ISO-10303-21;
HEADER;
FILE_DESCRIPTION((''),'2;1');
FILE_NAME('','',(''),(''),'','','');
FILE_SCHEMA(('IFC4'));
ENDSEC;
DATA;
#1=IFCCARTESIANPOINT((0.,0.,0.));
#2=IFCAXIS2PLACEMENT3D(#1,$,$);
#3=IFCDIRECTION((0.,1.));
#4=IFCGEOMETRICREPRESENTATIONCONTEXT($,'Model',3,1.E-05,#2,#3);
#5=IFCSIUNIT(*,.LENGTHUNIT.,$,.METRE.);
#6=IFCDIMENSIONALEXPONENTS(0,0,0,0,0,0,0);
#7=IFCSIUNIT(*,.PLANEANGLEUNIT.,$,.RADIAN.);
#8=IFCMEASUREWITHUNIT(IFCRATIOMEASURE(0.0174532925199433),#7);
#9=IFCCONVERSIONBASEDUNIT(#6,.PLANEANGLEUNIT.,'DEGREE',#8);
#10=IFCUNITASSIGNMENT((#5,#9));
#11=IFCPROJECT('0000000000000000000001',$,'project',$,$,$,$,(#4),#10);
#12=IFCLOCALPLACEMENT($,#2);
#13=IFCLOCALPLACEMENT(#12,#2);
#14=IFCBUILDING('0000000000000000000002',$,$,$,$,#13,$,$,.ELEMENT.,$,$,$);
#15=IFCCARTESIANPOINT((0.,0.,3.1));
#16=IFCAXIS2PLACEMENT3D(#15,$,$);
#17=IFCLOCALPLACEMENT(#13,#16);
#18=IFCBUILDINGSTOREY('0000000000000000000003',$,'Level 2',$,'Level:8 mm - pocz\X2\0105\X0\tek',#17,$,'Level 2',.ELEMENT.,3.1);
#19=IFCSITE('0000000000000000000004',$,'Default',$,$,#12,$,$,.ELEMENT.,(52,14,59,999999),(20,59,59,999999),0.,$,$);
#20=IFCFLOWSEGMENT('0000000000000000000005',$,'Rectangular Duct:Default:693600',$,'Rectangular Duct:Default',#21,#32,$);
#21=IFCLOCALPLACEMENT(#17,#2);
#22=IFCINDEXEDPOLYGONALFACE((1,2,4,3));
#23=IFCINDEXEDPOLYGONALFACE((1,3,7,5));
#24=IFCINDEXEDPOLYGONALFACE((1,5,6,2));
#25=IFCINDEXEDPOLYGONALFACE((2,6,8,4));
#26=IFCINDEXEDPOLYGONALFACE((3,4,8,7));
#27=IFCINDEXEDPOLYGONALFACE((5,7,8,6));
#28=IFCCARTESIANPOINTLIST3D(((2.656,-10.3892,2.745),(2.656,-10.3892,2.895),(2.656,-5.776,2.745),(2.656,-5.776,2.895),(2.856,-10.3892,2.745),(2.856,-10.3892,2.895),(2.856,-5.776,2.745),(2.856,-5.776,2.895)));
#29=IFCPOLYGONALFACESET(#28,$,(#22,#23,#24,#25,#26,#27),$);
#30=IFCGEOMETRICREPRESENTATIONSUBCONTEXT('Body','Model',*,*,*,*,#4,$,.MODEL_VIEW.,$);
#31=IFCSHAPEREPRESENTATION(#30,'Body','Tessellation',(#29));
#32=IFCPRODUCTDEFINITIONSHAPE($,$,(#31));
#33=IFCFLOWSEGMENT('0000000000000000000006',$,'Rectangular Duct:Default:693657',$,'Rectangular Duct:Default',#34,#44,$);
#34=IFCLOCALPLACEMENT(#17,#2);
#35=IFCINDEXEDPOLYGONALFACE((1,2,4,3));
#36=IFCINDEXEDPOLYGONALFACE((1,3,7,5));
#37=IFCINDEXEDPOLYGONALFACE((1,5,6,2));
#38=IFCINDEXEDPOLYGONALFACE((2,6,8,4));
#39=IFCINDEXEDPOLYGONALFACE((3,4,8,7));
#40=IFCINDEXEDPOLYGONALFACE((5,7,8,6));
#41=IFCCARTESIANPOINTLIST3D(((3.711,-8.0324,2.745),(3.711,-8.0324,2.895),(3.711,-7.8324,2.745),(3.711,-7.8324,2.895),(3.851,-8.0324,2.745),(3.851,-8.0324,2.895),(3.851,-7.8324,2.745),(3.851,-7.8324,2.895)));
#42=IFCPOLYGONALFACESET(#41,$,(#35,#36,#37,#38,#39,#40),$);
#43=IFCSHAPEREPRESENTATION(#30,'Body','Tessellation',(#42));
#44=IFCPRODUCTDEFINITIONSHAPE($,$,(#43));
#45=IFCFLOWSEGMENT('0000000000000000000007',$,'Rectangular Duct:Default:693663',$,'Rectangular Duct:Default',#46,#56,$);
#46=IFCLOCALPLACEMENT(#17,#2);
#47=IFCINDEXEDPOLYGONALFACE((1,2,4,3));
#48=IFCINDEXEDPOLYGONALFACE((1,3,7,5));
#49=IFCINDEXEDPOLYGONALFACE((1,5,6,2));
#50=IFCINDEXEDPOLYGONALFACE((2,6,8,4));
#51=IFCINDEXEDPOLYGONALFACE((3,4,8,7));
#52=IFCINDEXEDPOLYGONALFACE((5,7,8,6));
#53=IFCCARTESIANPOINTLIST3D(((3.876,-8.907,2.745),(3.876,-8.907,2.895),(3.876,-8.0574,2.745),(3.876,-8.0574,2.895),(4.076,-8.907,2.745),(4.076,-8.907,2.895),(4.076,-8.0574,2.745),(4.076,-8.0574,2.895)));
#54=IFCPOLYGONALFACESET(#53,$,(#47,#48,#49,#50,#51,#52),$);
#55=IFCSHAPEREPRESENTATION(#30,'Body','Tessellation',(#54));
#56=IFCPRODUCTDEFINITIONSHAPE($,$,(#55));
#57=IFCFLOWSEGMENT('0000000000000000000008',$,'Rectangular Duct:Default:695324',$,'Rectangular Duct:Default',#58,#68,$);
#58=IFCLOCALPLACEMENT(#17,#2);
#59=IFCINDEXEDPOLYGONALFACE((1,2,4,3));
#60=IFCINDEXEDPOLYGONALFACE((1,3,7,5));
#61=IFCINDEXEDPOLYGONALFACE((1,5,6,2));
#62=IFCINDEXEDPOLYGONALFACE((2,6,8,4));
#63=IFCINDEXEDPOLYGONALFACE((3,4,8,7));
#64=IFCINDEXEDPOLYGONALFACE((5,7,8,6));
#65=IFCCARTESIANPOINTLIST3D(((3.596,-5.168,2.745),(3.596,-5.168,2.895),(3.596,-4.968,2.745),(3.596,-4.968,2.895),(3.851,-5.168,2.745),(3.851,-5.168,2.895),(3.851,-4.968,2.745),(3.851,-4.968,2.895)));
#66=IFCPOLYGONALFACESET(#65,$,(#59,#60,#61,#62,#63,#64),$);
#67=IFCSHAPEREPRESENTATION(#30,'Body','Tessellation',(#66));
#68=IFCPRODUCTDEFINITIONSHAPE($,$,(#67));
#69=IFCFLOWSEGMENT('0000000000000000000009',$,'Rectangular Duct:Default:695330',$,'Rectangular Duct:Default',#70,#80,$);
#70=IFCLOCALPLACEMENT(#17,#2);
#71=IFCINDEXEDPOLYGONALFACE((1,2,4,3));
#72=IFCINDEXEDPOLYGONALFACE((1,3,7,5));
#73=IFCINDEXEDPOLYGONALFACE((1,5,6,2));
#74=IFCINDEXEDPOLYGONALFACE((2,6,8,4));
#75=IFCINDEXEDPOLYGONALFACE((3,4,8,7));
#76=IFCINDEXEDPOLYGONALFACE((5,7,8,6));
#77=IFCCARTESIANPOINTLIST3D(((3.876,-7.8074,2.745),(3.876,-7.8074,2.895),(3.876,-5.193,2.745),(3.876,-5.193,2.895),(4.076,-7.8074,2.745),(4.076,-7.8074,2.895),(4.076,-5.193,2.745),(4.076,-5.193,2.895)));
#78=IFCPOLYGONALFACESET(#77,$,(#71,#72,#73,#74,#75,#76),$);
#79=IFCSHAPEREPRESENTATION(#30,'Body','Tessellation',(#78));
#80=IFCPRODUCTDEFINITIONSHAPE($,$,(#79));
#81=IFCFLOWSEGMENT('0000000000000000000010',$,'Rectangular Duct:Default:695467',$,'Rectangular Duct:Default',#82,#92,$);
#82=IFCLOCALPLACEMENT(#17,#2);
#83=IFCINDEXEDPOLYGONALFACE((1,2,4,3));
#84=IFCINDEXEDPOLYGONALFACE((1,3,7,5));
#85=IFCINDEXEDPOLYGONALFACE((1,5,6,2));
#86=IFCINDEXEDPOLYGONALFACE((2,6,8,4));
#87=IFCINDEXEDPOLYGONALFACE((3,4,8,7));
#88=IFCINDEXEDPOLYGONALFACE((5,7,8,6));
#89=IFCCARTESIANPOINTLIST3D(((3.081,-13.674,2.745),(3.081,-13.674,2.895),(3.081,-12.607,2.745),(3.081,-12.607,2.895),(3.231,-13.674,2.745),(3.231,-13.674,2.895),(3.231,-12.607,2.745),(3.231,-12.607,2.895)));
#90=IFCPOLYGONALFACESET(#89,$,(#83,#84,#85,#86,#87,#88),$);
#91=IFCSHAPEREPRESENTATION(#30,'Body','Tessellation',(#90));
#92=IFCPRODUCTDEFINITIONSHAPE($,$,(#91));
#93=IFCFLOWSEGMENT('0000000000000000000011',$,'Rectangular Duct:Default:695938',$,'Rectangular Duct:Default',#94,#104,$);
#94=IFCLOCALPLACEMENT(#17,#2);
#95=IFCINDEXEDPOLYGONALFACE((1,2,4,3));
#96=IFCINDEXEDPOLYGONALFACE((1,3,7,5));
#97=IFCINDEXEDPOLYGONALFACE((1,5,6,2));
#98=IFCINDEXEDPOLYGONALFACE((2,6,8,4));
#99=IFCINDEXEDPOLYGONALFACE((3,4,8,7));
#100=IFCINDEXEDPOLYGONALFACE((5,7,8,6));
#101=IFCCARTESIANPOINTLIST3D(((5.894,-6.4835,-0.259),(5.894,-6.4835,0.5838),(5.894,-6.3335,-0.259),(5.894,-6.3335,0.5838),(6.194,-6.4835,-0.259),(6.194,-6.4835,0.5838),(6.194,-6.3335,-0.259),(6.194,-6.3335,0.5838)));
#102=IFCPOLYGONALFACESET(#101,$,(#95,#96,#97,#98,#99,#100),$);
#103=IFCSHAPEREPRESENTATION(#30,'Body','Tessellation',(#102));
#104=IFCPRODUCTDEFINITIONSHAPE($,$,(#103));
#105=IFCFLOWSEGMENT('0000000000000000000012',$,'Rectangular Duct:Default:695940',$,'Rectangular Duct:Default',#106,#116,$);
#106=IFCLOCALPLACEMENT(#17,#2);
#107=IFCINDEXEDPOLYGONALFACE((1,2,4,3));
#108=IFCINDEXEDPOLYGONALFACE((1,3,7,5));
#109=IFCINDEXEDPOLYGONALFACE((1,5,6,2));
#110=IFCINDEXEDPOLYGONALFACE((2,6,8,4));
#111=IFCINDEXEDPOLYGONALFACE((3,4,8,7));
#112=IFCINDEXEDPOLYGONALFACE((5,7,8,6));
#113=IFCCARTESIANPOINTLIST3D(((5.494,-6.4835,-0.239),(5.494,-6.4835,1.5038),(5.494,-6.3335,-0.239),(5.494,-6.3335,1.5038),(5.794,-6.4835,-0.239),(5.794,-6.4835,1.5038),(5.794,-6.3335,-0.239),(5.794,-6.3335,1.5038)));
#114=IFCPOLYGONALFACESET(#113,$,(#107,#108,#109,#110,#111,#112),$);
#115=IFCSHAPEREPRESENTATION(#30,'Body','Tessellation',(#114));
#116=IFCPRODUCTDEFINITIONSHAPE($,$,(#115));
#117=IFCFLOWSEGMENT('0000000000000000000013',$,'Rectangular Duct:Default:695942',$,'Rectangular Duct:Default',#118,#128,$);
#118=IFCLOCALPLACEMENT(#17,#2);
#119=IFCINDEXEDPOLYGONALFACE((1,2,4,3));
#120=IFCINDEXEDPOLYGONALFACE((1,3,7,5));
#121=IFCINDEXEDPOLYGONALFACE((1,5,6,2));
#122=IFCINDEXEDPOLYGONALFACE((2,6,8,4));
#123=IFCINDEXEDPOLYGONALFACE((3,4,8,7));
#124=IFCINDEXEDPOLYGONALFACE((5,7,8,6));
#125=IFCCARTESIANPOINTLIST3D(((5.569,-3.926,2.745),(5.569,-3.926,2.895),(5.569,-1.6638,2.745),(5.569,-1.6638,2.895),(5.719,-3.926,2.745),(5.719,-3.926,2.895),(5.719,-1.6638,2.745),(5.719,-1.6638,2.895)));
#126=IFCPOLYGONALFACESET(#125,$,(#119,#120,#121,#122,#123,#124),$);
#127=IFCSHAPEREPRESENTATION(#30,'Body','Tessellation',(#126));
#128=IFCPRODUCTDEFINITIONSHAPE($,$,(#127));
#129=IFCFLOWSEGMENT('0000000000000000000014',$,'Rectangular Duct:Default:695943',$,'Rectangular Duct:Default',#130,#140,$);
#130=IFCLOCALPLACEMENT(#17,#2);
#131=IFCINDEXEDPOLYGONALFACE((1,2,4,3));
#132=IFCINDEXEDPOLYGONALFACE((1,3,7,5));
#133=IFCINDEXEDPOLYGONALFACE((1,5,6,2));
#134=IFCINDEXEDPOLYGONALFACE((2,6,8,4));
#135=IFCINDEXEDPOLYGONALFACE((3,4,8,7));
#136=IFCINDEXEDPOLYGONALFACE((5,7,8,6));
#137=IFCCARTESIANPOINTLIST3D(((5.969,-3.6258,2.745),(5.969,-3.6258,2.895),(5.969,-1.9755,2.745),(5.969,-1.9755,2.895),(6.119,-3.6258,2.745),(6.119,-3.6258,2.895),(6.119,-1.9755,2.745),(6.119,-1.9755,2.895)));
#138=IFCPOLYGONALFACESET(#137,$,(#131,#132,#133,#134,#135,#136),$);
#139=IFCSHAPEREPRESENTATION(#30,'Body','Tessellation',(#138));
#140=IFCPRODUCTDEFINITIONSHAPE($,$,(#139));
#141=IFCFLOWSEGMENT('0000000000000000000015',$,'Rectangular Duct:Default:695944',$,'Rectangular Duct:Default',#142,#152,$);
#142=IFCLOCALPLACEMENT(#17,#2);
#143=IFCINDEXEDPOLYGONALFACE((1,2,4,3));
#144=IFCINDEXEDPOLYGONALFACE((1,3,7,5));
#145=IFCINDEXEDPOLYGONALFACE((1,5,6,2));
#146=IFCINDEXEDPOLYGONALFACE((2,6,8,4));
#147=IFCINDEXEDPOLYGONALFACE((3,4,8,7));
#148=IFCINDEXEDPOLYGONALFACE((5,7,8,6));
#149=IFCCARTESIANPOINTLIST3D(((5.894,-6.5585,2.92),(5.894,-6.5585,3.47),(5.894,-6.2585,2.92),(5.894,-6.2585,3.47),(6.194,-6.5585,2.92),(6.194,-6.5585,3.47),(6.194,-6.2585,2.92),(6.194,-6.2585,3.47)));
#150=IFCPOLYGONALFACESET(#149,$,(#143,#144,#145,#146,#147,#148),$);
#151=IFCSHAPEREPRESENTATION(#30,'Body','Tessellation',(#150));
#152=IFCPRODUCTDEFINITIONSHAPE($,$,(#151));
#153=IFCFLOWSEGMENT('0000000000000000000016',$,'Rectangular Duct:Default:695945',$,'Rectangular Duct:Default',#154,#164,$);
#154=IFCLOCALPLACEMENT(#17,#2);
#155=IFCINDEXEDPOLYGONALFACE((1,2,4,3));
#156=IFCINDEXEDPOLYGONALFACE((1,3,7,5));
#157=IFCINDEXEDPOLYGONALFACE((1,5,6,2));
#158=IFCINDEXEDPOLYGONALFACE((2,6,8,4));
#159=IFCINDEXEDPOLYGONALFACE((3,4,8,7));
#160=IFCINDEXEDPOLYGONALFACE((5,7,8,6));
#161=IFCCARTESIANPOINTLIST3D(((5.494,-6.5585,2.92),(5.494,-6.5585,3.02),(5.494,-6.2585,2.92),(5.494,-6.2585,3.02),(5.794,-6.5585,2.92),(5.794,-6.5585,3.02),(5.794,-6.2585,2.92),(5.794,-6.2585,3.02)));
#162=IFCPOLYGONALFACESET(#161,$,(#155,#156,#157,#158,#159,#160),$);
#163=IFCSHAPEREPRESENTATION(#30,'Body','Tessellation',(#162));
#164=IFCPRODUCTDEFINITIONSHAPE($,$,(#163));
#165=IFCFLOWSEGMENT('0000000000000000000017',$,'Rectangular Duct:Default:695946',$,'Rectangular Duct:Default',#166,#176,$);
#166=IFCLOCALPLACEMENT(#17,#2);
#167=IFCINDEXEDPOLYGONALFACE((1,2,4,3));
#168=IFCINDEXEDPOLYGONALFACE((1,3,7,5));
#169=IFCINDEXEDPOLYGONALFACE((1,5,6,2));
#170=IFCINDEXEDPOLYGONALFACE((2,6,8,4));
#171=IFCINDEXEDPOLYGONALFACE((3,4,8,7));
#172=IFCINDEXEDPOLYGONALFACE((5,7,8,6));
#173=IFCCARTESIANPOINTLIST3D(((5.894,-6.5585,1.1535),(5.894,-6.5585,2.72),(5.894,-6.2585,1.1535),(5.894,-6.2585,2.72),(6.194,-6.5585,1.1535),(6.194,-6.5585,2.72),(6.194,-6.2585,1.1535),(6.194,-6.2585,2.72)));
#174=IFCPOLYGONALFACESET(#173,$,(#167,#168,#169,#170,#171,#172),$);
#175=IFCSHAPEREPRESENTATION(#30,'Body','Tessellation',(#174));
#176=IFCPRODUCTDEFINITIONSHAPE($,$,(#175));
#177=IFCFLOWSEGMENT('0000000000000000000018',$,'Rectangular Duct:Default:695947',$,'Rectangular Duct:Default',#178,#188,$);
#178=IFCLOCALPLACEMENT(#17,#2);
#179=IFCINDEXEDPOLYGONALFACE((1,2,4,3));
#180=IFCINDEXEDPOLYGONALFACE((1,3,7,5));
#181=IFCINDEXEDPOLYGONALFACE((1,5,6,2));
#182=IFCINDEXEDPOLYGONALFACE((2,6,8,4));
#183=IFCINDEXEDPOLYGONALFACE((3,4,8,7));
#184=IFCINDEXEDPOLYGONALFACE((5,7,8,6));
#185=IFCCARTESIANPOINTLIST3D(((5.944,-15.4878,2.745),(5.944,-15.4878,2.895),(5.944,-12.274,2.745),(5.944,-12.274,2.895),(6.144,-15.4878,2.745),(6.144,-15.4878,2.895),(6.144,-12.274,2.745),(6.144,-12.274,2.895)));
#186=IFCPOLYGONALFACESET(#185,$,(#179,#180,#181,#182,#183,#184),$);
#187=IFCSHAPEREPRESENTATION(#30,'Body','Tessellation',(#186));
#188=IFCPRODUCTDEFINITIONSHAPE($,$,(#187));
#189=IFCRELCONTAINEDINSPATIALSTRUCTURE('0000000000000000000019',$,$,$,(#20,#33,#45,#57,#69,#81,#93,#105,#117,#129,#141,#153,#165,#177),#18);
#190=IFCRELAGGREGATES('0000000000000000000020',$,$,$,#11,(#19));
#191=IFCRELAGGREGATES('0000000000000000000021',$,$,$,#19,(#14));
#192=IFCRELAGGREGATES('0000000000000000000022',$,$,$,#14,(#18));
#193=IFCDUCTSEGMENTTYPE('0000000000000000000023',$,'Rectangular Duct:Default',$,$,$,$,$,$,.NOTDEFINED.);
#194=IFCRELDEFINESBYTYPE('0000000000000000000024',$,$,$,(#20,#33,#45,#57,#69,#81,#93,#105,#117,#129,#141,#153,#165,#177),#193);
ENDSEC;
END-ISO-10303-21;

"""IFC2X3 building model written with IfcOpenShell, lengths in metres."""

from ifc_helpers import new_model, entity, si_unit, converted_unit, direction, frame, frame_2d, origin, origin_2d_with_axis, place, context, subcontext, project, spatial, rectangle, extrude, type_object, element, save


model = new_model("IFC2X3")

# Units and contexts
model_context = context("Model", 3, precision=1e-05, world=origin(), true_north=direction((0.0, 1.0)))
body_context = subcontext(model_context, "Body", "Model", "MODEL_VIEW")
ifc_project = project(units=[si_unit("LENGTHUNIT", "METRE"), converted_unit("PLANEANGLEUNIT", "DEGREE", entity("IfcRatioMeasure", 0.0174532925199433), si_unit("PLANEANGLEUNIT", "RADIAN"), dimensions=[0, 0, 0, 0, 0, 0, 0])], contexts=[model_context])

# Site, building, storey
site_placement = place(None, origin())
site = spatial("IfcSite", under=ifc_project, at=site_placement, Name="Default", CompositionType="ELEMENT", RefLatitude=(52, 14, 59, 999999), RefLongitude=(20, 59, 59, 999999), RefElevation=0.0)
building_placement = place(site_placement, origin())
building = spatial("IfcBuilding", under=site, at=building_placement, CompositionType="ELEMENT")
storey_placement = place(building_placement, frame((0.0, 0.0, 3.1)))
storey = spatial("IfcBuildingStorey", under=building, at=storey_placement, Name="Level 2", ObjectType="Level:8 mm - początek", LongName="Level 2", CompositionType="ELEMENT", Elevation=3.1)

# Flow segments
duct_segment_type = type_object("IfcDuctSegmentType", Name="Rectangular Duct:Default", PredefinedType="NOTDEFINED")
flow_segment_1_placement = place(storey_placement, origin())
element("IfcFlowSegment", 1, at=flow_segment_1_placement, inside=storey, type_object=duct_segment_type, Name="Rectangular Duct:Default:693600", ObjectType="Rectangular Duct:Default", context=body_context, shape_type="SweptSolid", body=[
    extrude(rectangle(XDim=4.6132, YDim=0.2, at=frame_2d((0.0, 0.0), x_axis=(1.0, 0.0))), frame((2.756, -8.0826, 2.745), z_axis=(0.0, 0.0, 1.0), x_axis=(0.0, 1.0, 0.0)), (0.0, 0.0, 1.0), 0.15),
])
flow_segment_2_placement = place(storey_placement, origin())
element("IfcFlowSegment", 2, at=flow_segment_2_placement, inside=storey, type_object=duct_segment_type, Name="Rectangular Duct:Default:693657", ObjectType="Rectangular Duct:Default", context=body_context, shape_type="SweptSolid", body=[
    extrude(rectangle(XDim=0.14, YDim=0.2, at=frame_2d((0.0, 0.0), x_axis=(1.0, 0.0))), frame((3.781, -7.9324, 2.745), z_axis=(0.0, 0.0, 1.0), x_axis=(-1.0, 0.0, 0.0)), (0.0, 0.0, 1.0), 0.15),
])
flow_segment_3_placement = place(storey_placement, origin())
element("IfcFlowSegment", 3, at=flow_segment_3_placement, inside=storey, type_object=duct_segment_type, Name="Rectangular Duct:Default:693663", ObjectType="Rectangular Duct:Default", context=body_context, shape_type="SweptSolid", body=[
    extrude(rectangle(XDim=0.8496, YDim=0.2, at=frame_2d((0.0, 0.0), x_axis=(1.0, 0.0))), frame((3.976, -8.4822, 2.745), z_axis=(0.0, 0.0, 1.0), x_axis=(0.0, 1.0, 0.0)), (0.0, 0.0, 1.0), 0.15),
])
flow_segment_4_placement = place(storey_placement, origin())
element("IfcFlowSegment", 4, at=flow_segment_4_placement, inside=storey, type_object=duct_segment_type, Name="Rectangular Duct:Default:695324", ObjectType="Rectangular Duct:Default", context=body_context, shape_type="SweptSolid", body=[
    extrude(rectangle(XDim=0.255, YDim=0.2, at=origin_2d_with_axis()), frame((3.7235, -5.068, 2.745), z_axis=(0.0, 0.0, 1.0), x_axis=(-1.0, 0.0, 0.0)), (0.0, 0.0, 1.0), 0.15),
])
flow_segment_5_placement = place(storey_placement, origin())
element("IfcFlowSegment", 5, at=flow_segment_5_placement, inside=storey, type_object=duct_segment_type, Name="Rectangular Duct:Default:695330", ObjectType="Rectangular Duct:Default", context=body_context, shape_type="SweptSolid", body=[
    extrude(rectangle(XDim=2.6144, YDim=0.2, at=frame_2d((0.0, 0.0), x_axis=(1.0, 0.0))), frame((3.976, -6.5002, 2.745), z_axis=(0.0, 0.0, 1.0), x_axis=(0.0, 1.0, 0.0)), (0.0, 0.0, 1.0), 0.15),
])
flow_segment_6_placement = place(storey_placement, origin())
element("IfcFlowSegment", 6, at=flow_segment_6_placement, inside=storey, type_object=duct_segment_type, Name="Rectangular Duct:Default:695467", ObjectType="Rectangular Duct:Default", context=body_context, shape_type="SweptSolid", body=[
    extrude(rectangle(XDim=1.067, YDim=0.15, at=origin_2d_with_axis()), frame((3.156, -13.1405, 2.745), z_axis=(0.0, 0.0, 1.0), x_axis=(0.0, -1.0, 0.0)), (0.0, 0.0, 1.0), 0.15),
])
flow_segment_7_placement = place(storey_placement, origin())
element("IfcFlowSegment", 7, at=flow_segment_7_placement, inside=storey, type_object=duct_segment_type, Name="Rectangular Duct:Default:695938", ObjectType="Rectangular Duct:Default", context=body_context, shape_type="SweptSolid", body=[
    extrude(rectangle(XDim=0.15, YDim=0.3, at=frame_2d((0.0, 0.0), x_axis=(1.0, 0.0))), frame((6.044, -6.4085, -0.259), z_axis=(0.0, 0.0, 1.0), x_axis=(0.0, -1.0, 0.0)), (0.0, 0.0, 1.0), 0.8428),
])
flow_segment_8_placement = place(storey_placement, origin())
element("IfcFlowSegment", 8, at=flow_segment_8_placement, inside=storey, type_object=duct_segment_type, Name="Rectangular Duct:Default:695940", ObjectType="Rectangular Duct:Default", context=body_context, shape_type="SweptSolid", body=[
    extrude(rectangle(XDim=0.15, YDim=0.3, at=frame_2d((0.0, 0.0), x_axis=(1.0, 0.0))), frame((5.644, -6.4085, -0.239), z_axis=(0.0, 0.0, 1.0), x_axis=(0.0, -1.0, 0.0)), (0.0, 0.0, 1.0), 1.7428),
])
flow_segment_9_placement = place(storey_placement, origin())
element("IfcFlowSegment", 9, at=flow_segment_9_placement, inside=storey, type_object=duct_segment_type, Name="Rectangular Duct:Default:695942", ObjectType="Rectangular Duct:Default", context=body_context, shape_type="SweptSolid", body=[
    extrude(rectangle(XDim=2.2622, YDim=0.15, at=frame_2d((0.0, 0.0), x_axis=(1.0, 0.0))), frame((5.644, -2.7949, 2.745), z_axis=(0.0, 0.0, 1.0), x_axis=(0.0, 1.0, 0.0)), (0.0, 0.0, 1.0), 0.15),
])
flow_segment_10_placement = place(storey_placement, origin())
element("IfcFlowSegment", 10, at=flow_segment_10_placement, inside=storey, type_object=duct_segment_type, Name="Rectangular Duct:Default:695943", ObjectType="Rectangular Duct:Default", context=body_context, shape_type="SweptSolid", body=[
    extrude(rectangle(XDim=1.6504, YDim=0.15, at=origin_2d_with_axis()), frame((6.044, -2.8006, 2.745), z_axis=(0.0, 0.0, 1.0), x_axis=(0.0, 1.0, 0.0)), (0.0, 0.0, 1.0), 0.15),
])
flow_segment_11_placement = place(storey_placement, origin())
element("IfcFlowSegment", 11, at=flow_segment_11_placement, inside=storey, type_object=duct_segment_type, Name="Rectangular Duct:Default:695944", ObjectType="Rectangular Duct:Default", context=body_context, shape_type="SweptSolid", body=[
    extrude(rectangle(XDim=0.3, YDim=0.3, at=frame_2d((0.0, 0.0), x_axis=(1.0, 0.0))), frame((6.044, -6.4085, 2.92), z_axis=(0.0, 0.0, 1.0), x_axis=(0.0, 1.0, 0.0)), (0.0, 0.0, 1.0), 0.55),
])
flow_segment_12_placement = place(storey_placement, origin())
element("IfcFlowSegment", 12, at=flow_segment_12_placement, inside=storey, type_object=duct_segment_type, Name="Rectangular Duct:Default:695945", ObjectType="Rectangular Duct:Default", context=body_context, shape_type="SweptSolid", body=[
    extrude(rectangle(XDim=0.3, YDim=0.3, at=frame_2d((0.0, 0.0), x_axis=(1.0, 0.0))), frame((5.644, -6.4085, 2.92), z_axis=(0.0, 0.0, 1.0), x_axis=(0.0, 1.0, 0.0)), (0.0, 0.0, 1.0), 0.1),
])
flow_segment_13_placement = place(storey_placement, origin())
element("IfcFlowSegment", 13, at=flow_segment_13_placement, inside=storey, type_object=duct_segment_type, Name="Rectangular Duct:Default:695946", ObjectType="Rectangular Duct:Default", context=body_context, shape_type="SweptSolid", body=[
    extrude(rectangle(XDim=0.3, YDim=0.3, at=frame_2d((0.0, 0.0), x_axis=(1.0, 0.0))), frame((6.044, -6.4085, 1.1535), z_axis=(0.0, 0.0, 1.0), x_axis=(0.0, -1.0, 0.0)), (0.0, 0.0, 1.0), 1.5665),
])
flow_segment_14_placement = place(storey_placement, origin())
element("IfcFlowSegment", 14, at=flow_segment_14_placement, inside=storey, type_object=duct_segment_type, Name="Rectangular Duct:Default:695947", ObjectType="Rectangular Duct:Default", context=body_context, shape_type="SweptSolid", body=[
    extrude(rectangle(XDim=3.2138, YDim=0.2, at=origin_2d_with_axis()), frame((6.044, -13.8809, 2.745), z_axis=(0.0, 0.0, 1.0), x_axis=(0.0, 1.0, 0.0)), (0.0, 0.0, 1.0), 0.15),
])

save(model, "model.ifc")
